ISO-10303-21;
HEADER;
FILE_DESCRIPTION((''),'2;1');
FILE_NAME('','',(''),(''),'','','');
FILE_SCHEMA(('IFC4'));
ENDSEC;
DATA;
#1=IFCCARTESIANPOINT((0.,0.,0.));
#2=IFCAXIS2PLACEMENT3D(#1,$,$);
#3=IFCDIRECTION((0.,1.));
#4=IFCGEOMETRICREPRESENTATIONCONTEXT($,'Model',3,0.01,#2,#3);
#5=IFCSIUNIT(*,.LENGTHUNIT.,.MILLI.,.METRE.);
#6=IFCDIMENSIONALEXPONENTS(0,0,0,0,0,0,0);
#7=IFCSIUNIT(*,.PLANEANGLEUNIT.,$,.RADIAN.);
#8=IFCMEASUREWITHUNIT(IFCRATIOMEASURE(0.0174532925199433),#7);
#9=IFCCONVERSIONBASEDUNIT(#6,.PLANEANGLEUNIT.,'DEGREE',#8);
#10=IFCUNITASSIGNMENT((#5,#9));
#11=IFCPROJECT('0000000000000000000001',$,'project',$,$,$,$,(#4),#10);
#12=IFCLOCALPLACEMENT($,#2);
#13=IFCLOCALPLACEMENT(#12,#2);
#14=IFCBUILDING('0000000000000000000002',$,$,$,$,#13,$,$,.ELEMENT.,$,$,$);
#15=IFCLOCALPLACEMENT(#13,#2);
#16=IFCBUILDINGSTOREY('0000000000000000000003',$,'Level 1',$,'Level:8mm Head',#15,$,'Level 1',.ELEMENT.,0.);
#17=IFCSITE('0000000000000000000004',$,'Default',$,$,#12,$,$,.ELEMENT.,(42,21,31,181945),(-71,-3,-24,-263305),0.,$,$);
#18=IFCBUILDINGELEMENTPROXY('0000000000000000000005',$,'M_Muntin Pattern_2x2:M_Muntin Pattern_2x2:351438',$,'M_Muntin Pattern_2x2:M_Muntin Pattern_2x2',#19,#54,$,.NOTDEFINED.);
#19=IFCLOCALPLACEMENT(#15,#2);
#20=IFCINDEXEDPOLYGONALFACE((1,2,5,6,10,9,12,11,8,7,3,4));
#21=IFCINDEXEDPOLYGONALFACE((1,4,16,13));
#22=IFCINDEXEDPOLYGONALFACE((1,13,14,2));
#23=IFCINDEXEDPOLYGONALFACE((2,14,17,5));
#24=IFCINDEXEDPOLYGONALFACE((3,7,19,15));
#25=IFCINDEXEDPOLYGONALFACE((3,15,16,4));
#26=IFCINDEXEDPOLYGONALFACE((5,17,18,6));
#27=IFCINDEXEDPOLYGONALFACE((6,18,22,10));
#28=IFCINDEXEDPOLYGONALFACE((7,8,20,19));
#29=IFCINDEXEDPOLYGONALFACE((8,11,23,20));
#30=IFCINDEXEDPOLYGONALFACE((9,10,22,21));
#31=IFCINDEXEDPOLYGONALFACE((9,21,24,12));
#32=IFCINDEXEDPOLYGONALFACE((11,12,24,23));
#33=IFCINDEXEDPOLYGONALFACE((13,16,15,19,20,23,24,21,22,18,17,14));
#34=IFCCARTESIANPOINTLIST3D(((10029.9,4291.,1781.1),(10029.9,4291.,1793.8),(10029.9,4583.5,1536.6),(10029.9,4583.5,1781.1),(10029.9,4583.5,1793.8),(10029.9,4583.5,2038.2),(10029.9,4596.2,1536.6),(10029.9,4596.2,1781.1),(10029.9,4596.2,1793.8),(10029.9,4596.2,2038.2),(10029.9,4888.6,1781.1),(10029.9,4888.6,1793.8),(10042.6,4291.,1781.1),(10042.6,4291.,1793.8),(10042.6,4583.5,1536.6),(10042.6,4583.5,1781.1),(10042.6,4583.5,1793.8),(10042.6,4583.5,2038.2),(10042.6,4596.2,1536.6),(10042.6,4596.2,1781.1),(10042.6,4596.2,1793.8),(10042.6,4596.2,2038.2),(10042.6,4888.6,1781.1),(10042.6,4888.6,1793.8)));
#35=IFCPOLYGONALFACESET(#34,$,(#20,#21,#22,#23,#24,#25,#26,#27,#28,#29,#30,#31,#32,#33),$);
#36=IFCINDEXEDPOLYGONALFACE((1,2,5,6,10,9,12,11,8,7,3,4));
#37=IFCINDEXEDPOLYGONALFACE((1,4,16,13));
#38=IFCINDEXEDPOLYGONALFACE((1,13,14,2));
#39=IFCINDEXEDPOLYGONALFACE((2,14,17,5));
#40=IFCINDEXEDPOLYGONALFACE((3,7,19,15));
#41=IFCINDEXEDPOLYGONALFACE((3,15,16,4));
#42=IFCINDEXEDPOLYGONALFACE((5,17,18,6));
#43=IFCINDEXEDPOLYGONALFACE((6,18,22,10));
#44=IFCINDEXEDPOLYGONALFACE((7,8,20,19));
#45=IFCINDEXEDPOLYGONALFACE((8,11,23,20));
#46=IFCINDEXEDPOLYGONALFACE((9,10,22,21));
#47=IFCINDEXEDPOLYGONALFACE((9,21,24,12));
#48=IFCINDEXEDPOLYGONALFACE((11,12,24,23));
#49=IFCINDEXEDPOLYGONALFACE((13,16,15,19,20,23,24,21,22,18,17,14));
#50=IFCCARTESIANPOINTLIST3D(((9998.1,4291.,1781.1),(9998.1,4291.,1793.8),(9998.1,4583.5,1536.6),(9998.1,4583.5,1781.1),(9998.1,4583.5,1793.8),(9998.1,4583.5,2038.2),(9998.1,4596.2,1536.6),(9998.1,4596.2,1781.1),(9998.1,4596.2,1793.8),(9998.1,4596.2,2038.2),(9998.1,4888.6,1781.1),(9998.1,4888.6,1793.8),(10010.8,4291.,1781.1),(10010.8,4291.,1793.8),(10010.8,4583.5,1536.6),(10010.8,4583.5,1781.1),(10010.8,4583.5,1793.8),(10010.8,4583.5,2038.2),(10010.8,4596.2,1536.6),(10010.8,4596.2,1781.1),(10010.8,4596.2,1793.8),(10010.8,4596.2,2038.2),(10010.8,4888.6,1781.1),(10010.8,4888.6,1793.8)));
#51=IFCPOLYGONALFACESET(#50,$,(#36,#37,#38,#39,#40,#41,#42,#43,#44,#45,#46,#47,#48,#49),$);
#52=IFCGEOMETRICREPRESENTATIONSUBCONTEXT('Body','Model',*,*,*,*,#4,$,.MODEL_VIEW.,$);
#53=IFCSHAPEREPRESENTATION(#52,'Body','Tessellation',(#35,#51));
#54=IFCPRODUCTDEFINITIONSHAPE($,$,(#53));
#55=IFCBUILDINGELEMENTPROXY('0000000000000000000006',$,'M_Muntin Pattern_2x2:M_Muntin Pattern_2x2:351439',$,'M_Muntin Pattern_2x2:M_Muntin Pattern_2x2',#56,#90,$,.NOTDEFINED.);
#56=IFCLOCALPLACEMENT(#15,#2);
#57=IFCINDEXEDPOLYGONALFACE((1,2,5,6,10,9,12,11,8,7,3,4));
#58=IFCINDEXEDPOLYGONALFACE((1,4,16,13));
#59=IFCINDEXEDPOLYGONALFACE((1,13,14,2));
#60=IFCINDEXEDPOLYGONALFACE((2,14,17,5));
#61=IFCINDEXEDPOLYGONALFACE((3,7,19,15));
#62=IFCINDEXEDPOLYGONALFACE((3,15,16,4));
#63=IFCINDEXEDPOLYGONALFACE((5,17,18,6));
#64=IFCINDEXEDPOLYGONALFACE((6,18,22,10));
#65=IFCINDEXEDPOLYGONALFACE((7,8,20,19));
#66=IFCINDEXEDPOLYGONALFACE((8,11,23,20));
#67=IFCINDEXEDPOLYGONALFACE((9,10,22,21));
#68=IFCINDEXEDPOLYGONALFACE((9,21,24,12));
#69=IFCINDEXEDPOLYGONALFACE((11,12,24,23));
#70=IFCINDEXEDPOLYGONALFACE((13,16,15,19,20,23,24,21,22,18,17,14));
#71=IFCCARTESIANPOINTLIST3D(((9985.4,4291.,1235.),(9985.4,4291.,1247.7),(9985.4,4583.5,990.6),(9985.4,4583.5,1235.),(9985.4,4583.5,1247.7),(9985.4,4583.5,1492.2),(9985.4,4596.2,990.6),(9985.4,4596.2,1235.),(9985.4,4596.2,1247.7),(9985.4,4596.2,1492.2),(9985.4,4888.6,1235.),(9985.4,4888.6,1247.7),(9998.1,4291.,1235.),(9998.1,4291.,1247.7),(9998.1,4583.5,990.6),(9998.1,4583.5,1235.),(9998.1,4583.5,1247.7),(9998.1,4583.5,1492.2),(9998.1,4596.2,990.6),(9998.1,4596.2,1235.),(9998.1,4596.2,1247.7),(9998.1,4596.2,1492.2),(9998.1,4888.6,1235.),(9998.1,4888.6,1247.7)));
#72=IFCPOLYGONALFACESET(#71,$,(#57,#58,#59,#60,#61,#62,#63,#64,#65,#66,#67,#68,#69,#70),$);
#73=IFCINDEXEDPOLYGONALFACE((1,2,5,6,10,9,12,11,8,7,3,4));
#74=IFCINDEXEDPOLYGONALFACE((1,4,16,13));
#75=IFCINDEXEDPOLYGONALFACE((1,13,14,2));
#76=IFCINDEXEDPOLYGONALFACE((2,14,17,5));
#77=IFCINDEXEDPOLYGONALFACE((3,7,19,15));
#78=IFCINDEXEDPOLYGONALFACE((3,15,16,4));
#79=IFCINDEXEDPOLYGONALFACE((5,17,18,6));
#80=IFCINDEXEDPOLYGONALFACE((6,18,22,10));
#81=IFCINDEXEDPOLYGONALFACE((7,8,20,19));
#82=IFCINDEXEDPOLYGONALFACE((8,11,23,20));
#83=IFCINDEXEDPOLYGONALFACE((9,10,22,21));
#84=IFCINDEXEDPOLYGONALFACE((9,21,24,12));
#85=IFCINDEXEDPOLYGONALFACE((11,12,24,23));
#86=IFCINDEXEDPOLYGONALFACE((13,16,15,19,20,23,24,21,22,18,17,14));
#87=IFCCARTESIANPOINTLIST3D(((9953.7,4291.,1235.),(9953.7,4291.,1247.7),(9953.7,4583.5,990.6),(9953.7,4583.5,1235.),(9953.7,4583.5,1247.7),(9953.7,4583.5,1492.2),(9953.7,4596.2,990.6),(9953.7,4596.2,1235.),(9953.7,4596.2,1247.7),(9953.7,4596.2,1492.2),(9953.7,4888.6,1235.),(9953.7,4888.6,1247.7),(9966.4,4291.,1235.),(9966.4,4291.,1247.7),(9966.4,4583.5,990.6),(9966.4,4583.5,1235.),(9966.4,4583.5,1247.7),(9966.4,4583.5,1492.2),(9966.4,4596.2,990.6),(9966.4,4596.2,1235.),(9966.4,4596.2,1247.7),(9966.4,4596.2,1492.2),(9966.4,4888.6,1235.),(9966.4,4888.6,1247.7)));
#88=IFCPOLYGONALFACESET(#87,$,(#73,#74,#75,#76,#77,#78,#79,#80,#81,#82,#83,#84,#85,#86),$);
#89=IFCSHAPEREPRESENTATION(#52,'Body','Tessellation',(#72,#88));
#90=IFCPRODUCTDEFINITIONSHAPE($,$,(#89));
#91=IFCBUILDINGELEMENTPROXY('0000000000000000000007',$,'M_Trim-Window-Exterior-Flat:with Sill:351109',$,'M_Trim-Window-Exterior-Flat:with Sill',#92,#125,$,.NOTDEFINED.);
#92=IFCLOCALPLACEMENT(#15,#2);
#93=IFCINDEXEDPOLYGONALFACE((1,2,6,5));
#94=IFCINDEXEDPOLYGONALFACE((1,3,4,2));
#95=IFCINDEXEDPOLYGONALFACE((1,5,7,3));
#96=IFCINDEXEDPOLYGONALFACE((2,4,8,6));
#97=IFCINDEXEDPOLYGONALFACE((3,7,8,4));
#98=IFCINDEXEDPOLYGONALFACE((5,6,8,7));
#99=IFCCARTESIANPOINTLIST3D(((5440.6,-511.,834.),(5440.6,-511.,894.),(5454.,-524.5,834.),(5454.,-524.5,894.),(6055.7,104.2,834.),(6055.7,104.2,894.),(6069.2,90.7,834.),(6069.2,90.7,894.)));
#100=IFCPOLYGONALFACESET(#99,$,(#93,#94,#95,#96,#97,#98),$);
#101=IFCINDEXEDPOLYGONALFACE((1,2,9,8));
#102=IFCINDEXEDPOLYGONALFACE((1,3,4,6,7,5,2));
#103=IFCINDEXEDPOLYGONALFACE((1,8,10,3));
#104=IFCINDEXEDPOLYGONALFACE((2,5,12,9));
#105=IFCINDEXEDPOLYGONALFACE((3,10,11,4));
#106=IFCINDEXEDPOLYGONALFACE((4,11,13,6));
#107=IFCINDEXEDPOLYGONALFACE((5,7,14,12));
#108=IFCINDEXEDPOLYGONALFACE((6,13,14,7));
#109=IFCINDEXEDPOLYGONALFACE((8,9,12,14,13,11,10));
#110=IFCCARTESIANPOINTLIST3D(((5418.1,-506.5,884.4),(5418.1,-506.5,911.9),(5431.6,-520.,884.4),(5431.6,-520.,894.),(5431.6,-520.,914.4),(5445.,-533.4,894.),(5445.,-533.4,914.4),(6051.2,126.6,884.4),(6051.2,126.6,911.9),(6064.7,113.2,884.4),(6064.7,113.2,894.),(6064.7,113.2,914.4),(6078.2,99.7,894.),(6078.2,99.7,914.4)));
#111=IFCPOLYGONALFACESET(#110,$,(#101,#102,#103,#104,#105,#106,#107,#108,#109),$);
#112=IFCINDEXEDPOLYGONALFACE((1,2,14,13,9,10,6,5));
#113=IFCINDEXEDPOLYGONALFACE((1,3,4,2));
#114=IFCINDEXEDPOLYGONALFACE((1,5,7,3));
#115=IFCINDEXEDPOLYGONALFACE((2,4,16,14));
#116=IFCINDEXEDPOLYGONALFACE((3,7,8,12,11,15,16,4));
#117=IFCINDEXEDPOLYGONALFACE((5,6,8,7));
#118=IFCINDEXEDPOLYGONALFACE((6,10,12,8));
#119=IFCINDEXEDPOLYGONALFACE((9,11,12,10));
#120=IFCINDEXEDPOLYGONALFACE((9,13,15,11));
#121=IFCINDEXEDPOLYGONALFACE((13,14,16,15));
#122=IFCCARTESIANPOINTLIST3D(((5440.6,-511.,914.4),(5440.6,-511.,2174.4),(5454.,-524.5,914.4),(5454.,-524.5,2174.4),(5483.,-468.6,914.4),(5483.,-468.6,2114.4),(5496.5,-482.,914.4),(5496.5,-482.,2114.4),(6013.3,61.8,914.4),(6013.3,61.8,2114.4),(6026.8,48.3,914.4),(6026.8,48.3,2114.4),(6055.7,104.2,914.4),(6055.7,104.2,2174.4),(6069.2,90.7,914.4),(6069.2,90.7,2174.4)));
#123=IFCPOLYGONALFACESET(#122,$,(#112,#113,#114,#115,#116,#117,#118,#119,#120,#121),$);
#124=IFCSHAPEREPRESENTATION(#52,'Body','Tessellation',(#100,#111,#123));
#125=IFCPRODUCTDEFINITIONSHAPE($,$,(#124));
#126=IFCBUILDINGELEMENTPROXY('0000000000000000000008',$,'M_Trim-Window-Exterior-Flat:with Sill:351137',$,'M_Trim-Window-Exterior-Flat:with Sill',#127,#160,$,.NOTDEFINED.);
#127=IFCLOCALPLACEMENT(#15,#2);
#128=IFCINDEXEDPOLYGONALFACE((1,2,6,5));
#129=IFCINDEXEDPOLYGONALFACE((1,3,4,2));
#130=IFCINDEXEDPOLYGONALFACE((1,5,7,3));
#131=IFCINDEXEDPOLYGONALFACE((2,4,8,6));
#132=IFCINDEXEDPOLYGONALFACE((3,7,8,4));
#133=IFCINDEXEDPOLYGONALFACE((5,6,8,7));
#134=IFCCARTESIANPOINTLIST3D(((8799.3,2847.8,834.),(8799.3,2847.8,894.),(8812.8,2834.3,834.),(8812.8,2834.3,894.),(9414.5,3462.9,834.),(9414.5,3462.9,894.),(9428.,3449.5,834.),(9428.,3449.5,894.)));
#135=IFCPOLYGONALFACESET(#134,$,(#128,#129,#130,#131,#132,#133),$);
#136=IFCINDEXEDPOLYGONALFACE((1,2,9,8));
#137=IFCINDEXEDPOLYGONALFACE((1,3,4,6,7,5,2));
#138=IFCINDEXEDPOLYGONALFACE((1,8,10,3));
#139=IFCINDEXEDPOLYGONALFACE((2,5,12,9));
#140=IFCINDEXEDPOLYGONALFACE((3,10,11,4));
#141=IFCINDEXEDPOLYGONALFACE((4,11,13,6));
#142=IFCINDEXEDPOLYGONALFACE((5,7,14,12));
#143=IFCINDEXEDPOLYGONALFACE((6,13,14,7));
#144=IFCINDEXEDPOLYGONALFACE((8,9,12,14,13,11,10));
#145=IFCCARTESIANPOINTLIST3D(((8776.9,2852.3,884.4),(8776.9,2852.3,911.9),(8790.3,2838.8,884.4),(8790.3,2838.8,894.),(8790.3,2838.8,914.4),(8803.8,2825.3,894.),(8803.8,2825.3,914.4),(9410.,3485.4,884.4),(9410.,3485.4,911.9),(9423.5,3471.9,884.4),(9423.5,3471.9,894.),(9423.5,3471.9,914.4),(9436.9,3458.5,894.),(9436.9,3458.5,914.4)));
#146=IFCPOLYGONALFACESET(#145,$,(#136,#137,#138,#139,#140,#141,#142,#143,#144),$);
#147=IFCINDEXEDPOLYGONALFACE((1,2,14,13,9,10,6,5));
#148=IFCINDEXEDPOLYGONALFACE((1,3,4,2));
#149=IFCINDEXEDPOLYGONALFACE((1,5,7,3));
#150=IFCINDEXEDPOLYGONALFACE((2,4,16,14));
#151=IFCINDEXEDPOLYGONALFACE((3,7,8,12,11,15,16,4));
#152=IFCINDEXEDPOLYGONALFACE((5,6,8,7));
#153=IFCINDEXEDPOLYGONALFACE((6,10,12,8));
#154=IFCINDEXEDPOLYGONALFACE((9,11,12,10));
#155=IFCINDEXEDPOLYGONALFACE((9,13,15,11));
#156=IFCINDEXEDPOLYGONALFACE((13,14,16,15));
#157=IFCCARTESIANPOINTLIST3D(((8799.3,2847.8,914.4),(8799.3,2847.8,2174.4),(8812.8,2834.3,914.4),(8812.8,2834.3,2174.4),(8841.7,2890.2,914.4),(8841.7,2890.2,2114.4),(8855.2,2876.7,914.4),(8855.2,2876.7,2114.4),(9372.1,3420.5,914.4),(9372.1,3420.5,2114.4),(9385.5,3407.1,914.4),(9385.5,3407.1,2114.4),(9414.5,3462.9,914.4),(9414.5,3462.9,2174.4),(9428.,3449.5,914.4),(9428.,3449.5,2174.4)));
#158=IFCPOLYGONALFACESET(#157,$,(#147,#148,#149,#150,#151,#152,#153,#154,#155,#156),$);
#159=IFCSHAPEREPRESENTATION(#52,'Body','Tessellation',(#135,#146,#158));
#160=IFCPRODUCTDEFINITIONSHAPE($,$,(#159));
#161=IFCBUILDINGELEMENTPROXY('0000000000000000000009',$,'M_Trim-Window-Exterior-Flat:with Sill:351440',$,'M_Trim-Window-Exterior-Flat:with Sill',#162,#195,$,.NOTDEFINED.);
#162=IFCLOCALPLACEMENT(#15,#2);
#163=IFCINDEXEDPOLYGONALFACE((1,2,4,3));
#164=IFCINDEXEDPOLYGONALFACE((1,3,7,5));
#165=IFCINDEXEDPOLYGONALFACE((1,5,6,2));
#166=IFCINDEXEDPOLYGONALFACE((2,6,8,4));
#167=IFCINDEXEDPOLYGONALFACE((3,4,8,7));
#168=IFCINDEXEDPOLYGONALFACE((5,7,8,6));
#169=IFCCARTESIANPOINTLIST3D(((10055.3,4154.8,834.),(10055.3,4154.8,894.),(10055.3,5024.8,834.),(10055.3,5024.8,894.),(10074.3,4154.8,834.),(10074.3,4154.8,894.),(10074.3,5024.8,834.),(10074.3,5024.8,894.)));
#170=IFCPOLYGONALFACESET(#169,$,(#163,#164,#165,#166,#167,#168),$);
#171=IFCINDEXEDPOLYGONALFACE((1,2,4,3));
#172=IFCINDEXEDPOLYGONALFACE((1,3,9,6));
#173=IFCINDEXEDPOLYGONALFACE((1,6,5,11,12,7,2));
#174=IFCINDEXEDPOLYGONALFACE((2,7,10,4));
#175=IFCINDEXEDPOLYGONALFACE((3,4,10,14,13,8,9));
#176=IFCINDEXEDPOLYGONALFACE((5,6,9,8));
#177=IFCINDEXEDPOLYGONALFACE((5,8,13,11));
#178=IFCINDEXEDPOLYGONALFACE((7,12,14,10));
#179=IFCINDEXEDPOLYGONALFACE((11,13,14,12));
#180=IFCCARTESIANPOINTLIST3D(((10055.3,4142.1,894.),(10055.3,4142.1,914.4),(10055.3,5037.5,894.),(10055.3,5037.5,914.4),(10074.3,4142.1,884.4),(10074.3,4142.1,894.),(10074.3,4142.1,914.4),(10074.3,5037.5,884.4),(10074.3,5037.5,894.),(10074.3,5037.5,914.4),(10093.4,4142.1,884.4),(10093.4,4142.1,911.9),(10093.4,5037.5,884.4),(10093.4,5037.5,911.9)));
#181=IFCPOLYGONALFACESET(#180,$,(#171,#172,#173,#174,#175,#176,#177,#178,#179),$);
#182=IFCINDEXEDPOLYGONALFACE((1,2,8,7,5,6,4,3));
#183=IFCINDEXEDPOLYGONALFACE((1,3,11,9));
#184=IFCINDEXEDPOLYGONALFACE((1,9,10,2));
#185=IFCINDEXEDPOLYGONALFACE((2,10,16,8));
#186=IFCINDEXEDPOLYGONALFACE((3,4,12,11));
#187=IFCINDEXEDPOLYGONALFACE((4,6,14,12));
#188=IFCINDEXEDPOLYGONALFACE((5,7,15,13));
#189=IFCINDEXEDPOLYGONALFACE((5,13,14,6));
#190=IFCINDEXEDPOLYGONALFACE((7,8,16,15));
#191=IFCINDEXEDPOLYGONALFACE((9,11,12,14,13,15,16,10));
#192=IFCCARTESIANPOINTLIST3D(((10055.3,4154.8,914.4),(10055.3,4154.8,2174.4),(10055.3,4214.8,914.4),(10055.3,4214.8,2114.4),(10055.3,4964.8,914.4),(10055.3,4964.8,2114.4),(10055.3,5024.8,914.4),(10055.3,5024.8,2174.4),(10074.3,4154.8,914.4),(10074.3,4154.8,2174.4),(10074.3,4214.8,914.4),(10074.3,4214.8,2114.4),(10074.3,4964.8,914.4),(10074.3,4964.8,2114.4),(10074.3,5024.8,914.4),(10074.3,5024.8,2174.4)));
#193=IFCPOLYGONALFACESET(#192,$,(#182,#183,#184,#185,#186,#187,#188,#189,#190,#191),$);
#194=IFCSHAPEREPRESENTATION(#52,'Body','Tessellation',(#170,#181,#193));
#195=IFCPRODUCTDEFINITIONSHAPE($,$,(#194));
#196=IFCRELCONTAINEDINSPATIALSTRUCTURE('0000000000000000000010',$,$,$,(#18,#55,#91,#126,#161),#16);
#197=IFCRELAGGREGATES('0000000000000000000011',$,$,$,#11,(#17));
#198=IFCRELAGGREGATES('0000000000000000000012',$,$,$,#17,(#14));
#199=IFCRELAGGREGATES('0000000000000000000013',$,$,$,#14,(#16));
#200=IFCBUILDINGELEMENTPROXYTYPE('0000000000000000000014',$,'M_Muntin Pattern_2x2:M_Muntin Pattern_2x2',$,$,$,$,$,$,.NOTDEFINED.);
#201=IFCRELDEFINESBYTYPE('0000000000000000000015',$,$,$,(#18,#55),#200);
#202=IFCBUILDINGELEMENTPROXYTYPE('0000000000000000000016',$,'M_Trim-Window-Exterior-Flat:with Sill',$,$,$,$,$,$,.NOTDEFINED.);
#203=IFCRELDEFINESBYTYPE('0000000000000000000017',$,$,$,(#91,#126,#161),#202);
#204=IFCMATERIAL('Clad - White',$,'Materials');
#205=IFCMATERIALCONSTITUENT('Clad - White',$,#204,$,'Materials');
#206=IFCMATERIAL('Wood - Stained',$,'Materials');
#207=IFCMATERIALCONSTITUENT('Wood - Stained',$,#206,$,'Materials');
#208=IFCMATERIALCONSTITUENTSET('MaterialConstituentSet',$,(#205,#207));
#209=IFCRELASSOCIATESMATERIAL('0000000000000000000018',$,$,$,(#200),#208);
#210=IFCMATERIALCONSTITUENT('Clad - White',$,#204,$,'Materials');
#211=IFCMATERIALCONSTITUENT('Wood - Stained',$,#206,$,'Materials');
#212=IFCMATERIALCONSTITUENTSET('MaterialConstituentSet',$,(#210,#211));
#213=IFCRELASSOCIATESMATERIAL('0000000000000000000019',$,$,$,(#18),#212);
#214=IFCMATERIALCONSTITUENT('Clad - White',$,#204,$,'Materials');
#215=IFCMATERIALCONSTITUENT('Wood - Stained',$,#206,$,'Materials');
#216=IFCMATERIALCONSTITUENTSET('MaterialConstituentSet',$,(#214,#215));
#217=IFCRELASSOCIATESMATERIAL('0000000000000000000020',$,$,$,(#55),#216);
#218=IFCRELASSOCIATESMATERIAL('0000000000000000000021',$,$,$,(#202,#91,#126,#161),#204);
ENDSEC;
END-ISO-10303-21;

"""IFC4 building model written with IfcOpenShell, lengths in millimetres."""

from ifc_helpers import new_model, entity, si_unit, converted_unit, direction, frame, frame_2d, origin, place, context, subcontext, project, spatial, polyline, rectangle, outline, extrude, source, transform, mapped, material, constituent, constituent_set, type_object, type_shapes, element, save


model = new_model("IFC4")

# Units and contexts
model_context = context("Model", 3, precision=0.01, world=origin(), true_north=direction((0.0, 1.0)))
body_context = subcontext(model_context, "Body", "Model", "MODEL_VIEW")
ifc_project = project(units=[si_unit("LENGTHUNIT", "METRE", prefix="MILLI"), converted_unit("PLANEANGLEUNIT", "DEGREE", entity("IfcRatioMeasure", 0.0174532925199433), si_unit("PLANEANGLEUNIT", "RADIAN"), dimensions=[0, 0, 0, 0, 0, 0, 0])], contexts=[model_context])

# Site, building, storey
site_placement = place(None, origin())
site = spatial("IfcSite", under=ifc_project, at=site_placement, Name="Default", CompositionType="ELEMENT", RefLatitude=(42, 21, 31, 181945), RefLongitude=(-71, -3, -24, -263305), RefElevation=0.0)
building_placement = place(site_placement, origin())
building = spatial("IfcBuilding", under=site, at=building_placement, CompositionType="ELEMENT")
storey_placement = place(building_placement, origin())
storey = spatial("IfcBuildingStorey", under=building, at=storey_placement, Name="Level 1", ObjectType="Level:8mm Head", LongName="Level 1", CompositionType="ELEMENT", Elevation=0.0)

# Shared definitions
ifc_material_1 = material(Name="Wood - Stained", Category="Materials")

# Building element proxies
ifc_material_2 = material(Name="Clad - White", Category="Materials")
ifc_constituent_1 = constituent(ifc_material_2, Name="Clad - White", Category="Materials")
ifc_constituent_2 = constituent(ifc_material_1, Name="Wood - Stained", Category="Materials")
ifc_constituent_set_1 = constituent_set(constituents=[ifc_constituent_1, ifc_constituent_2], Name="MaterialConstituentSet")
building_element_proxy_type_1 = type_object("IfcBuildingElementProxyType", Name="M_Muntin Pattern_2x2:M_Muntin Pattern_2x2", PredefinedType="NOTDEFINED", material=ifc_constituent_set_1)
shared_shape_1 = source(origin(), body_context, "Body", "SweptSolid", [
    extrude(outline(polyline([(6.4, -6.4), (250.8, -6.4), (250.8, 6.3), (6.4, 6.3), (6.4, 298.8), (-6.3, 298.8), (-6.3, 6.3), (-250.8, 6.3), (-250.8, -6.4), (-6.3, -6.4), (-6.3, -298.8), (6.4, -298.8), (6.4, -6.4)])), frame((0.0, 9.5, 250.8), z_axis=(0.0, 1.0, 0.0), x_axis=(0.0, 0.0, 1.0)), (0.0, 0.0, 1.0), 12.7),
    extrude(outline(polyline([(6.4, -6.4), (250.8, -6.4), (250.8, 6.3), (6.4, 6.3), (6.4, 298.8), (-6.3, 298.8), (-6.3, 6.3), (-250.8, 6.3), (-250.8, -6.4), (-6.3, -6.4), (-6.3, -298.8), (6.4, -298.8), (6.4, -6.4)])), frame((0.0, -22.2, 250.8), z_axis=(0.0, 1.0, 0.0), x_axis=(0.0, 0.0, 1.0)), (0.0, 0.0, 1.0), 12.7),
])
type_shapes(building_element_proxy_type_1, [shared_shape_1])
ifc_constituent_3 = constituent(ifc_material_2, Name="Clad - White", Category="Materials")
ifc_constituent_4 = constituent(ifc_material_1, Name="Wood - Stained", Category="Materials")
ifc_constituent_set_2 = constituent_set(constituents=[ifc_constituent_3, ifc_constituent_4], Name="MaterialConstituentSet")
proxy_1_placement = place(storey_placement, frame((10020.3, 4589.8, 1536.6), z_axis=(0.0, 0.0, 1.0), x_axis=(0.0, -1.0, 0.0)))
element("IfcBuildingElementProxy", 1, at=proxy_1_placement, inside=storey, type_object=building_element_proxy_type_1, material=ifc_constituent_set_2, Name="M_Muntin Pattern_2x2:M_Muntin Pattern_2x2:351438", ObjectType="M_Muntin Pattern_2x2:M_Muntin Pattern_2x2", PredefinedType="NOTDEFINED", context=body_context, shape_type="MappedRepresentation", body=[
    mapped(shared_shape_1, transform((0.0, 0.0, 0.0), scale=1.0)),
])
ifc_constituent_5 = constituent(ifc_material_2, Name="Clad - White", Category="Materials")
ifc_constituent_6 = constituent(ifc_material_1, Name="Wood - Stained", Category="Materials")
ifc_constituent_set_3 = constituent_set(constituents=[ifc_constituent_5, ifc_constituent_6], Name="MaterialConstituentSet")
proxy_2_placement = place(storey_placement, frame((9975.9, 4589.8, 990.6), z_axis=(0.0, 0.0, 1.0), x_axis=(0.0, -1.0, 0.0)))
element("IfcBuildingElementProxy", 2, at=proxy_2_placement, inside=storey, type_object=building_element_proxy_type_1, material=ifc_constituent_set_3, Name="M_Muntin Pattern_2x2:M_Muntin Pattern_2x2:351439", ObjectType="M_Muntin Pattern_2x2:M_Muntin Pattern_2x2", PredefinedType="NOTDEFINED", context=body_context, shape_type="MappedRepresentation", body=[
    mapped(shared_shape_1, transform((0.0, 0.0, 0.0), scale=1.0)),
])
building_element_proxy_type_2 = type_object("IfcBuildingElementProxyType", Name="M_Trim-Window-Exterior-Flat:with Sill", PredefinedType="NOTDEFINED", material=ifc_material_2)
shared_shape_2 = source(origin(), body_context, "Body", "SweptSolid", [
    extrude(rectangle(XDim=870.0, YDim=60.0, at=frame_2d((0.0, 0.0), x_axis=(1.0, 0.0))), frame((0.0, -1250.4, 0.0), z_axis=(0.0, 0.0, 1.0), x_axis=(-1.0, 0.0, 0.0)), (0.0, 0.0, 1.0), 19.1),
    extrude(outline(polyline([(-19.0, -15.2), (0.0, -15.2), (0.0, -5.7), (19.0, -5.7), (19.0, 14.8), (0.0, 14.8), (-19.0, 12.3), (-19.0, -15.2)])), frame((-447.7, -1214.8, 19.0), z_axis=(1.0, 0.0, 0.0), x_axis=(0.0, 0.0, -1.0)), (0.0, 0.0, 1.0), 895.4),
    extrude(outline(polyline([(-645.0, -435.0), (615.0, -435.0), (615.0, -375.0), (-585.0, -375.0), (-585.0, 375.0), (615.0, 375.0), (615.0, 435.0), (-645.0, 435.0), (-645.0, -435.0)])), frame((0.0, -585.0, 0.0), z_axis=(0.0, 0.0, 1.0), x_axis=(0.0, -1.0, 0.0)), (0.0, 0.0, 1.0), 19.1),
])
type_shapes(building_element_proxy_type_2, [shared_shape_2])
for number, where, z_axis, x_axis, name in (
    (3, (5761.6, -216.9, 2114.4), (-0.707107, 0.707107, 0.0), (-0.707107, -0.707107, 0.0), "M_Trim-Window-Exterior-Flat:with Sill:351109"),
    (4, (9120.4, 3141.9, 2114.4), (-0.707107, 0.707107, 0.0), (-0.707107, -0.707107, 0.0), "M_Trim-Window-Exterior-Flat:with Sill:351137"),
    (5, (10055.3, 4589.8, 2114.4), (1.0, 0.0, 0.0), (0.0, 1.0, 0.0), "M_Trim-Window-Exterior-Flat:with Sill:351440"),
):
    element("IfcBuildingElementProxy", number, at=place(storey_placement, frame(where, z_axis=z_axis, x_axis=x_axis)), inside=storey, type_object=building_element_proxy_type_2, material=ifc_material_2, Name=name, ObjectType="M_Trim-Window-Exterior-Flat:with Sill", PredefinedType="NOTDEFINED", context=body_context, shape_type="MappedRepresentation", body=[
        mapped(shared_shape_2, transform((0.0, 0.0, 0.0), scale=1.0)),
    ])

save(model, "model.ifc")
